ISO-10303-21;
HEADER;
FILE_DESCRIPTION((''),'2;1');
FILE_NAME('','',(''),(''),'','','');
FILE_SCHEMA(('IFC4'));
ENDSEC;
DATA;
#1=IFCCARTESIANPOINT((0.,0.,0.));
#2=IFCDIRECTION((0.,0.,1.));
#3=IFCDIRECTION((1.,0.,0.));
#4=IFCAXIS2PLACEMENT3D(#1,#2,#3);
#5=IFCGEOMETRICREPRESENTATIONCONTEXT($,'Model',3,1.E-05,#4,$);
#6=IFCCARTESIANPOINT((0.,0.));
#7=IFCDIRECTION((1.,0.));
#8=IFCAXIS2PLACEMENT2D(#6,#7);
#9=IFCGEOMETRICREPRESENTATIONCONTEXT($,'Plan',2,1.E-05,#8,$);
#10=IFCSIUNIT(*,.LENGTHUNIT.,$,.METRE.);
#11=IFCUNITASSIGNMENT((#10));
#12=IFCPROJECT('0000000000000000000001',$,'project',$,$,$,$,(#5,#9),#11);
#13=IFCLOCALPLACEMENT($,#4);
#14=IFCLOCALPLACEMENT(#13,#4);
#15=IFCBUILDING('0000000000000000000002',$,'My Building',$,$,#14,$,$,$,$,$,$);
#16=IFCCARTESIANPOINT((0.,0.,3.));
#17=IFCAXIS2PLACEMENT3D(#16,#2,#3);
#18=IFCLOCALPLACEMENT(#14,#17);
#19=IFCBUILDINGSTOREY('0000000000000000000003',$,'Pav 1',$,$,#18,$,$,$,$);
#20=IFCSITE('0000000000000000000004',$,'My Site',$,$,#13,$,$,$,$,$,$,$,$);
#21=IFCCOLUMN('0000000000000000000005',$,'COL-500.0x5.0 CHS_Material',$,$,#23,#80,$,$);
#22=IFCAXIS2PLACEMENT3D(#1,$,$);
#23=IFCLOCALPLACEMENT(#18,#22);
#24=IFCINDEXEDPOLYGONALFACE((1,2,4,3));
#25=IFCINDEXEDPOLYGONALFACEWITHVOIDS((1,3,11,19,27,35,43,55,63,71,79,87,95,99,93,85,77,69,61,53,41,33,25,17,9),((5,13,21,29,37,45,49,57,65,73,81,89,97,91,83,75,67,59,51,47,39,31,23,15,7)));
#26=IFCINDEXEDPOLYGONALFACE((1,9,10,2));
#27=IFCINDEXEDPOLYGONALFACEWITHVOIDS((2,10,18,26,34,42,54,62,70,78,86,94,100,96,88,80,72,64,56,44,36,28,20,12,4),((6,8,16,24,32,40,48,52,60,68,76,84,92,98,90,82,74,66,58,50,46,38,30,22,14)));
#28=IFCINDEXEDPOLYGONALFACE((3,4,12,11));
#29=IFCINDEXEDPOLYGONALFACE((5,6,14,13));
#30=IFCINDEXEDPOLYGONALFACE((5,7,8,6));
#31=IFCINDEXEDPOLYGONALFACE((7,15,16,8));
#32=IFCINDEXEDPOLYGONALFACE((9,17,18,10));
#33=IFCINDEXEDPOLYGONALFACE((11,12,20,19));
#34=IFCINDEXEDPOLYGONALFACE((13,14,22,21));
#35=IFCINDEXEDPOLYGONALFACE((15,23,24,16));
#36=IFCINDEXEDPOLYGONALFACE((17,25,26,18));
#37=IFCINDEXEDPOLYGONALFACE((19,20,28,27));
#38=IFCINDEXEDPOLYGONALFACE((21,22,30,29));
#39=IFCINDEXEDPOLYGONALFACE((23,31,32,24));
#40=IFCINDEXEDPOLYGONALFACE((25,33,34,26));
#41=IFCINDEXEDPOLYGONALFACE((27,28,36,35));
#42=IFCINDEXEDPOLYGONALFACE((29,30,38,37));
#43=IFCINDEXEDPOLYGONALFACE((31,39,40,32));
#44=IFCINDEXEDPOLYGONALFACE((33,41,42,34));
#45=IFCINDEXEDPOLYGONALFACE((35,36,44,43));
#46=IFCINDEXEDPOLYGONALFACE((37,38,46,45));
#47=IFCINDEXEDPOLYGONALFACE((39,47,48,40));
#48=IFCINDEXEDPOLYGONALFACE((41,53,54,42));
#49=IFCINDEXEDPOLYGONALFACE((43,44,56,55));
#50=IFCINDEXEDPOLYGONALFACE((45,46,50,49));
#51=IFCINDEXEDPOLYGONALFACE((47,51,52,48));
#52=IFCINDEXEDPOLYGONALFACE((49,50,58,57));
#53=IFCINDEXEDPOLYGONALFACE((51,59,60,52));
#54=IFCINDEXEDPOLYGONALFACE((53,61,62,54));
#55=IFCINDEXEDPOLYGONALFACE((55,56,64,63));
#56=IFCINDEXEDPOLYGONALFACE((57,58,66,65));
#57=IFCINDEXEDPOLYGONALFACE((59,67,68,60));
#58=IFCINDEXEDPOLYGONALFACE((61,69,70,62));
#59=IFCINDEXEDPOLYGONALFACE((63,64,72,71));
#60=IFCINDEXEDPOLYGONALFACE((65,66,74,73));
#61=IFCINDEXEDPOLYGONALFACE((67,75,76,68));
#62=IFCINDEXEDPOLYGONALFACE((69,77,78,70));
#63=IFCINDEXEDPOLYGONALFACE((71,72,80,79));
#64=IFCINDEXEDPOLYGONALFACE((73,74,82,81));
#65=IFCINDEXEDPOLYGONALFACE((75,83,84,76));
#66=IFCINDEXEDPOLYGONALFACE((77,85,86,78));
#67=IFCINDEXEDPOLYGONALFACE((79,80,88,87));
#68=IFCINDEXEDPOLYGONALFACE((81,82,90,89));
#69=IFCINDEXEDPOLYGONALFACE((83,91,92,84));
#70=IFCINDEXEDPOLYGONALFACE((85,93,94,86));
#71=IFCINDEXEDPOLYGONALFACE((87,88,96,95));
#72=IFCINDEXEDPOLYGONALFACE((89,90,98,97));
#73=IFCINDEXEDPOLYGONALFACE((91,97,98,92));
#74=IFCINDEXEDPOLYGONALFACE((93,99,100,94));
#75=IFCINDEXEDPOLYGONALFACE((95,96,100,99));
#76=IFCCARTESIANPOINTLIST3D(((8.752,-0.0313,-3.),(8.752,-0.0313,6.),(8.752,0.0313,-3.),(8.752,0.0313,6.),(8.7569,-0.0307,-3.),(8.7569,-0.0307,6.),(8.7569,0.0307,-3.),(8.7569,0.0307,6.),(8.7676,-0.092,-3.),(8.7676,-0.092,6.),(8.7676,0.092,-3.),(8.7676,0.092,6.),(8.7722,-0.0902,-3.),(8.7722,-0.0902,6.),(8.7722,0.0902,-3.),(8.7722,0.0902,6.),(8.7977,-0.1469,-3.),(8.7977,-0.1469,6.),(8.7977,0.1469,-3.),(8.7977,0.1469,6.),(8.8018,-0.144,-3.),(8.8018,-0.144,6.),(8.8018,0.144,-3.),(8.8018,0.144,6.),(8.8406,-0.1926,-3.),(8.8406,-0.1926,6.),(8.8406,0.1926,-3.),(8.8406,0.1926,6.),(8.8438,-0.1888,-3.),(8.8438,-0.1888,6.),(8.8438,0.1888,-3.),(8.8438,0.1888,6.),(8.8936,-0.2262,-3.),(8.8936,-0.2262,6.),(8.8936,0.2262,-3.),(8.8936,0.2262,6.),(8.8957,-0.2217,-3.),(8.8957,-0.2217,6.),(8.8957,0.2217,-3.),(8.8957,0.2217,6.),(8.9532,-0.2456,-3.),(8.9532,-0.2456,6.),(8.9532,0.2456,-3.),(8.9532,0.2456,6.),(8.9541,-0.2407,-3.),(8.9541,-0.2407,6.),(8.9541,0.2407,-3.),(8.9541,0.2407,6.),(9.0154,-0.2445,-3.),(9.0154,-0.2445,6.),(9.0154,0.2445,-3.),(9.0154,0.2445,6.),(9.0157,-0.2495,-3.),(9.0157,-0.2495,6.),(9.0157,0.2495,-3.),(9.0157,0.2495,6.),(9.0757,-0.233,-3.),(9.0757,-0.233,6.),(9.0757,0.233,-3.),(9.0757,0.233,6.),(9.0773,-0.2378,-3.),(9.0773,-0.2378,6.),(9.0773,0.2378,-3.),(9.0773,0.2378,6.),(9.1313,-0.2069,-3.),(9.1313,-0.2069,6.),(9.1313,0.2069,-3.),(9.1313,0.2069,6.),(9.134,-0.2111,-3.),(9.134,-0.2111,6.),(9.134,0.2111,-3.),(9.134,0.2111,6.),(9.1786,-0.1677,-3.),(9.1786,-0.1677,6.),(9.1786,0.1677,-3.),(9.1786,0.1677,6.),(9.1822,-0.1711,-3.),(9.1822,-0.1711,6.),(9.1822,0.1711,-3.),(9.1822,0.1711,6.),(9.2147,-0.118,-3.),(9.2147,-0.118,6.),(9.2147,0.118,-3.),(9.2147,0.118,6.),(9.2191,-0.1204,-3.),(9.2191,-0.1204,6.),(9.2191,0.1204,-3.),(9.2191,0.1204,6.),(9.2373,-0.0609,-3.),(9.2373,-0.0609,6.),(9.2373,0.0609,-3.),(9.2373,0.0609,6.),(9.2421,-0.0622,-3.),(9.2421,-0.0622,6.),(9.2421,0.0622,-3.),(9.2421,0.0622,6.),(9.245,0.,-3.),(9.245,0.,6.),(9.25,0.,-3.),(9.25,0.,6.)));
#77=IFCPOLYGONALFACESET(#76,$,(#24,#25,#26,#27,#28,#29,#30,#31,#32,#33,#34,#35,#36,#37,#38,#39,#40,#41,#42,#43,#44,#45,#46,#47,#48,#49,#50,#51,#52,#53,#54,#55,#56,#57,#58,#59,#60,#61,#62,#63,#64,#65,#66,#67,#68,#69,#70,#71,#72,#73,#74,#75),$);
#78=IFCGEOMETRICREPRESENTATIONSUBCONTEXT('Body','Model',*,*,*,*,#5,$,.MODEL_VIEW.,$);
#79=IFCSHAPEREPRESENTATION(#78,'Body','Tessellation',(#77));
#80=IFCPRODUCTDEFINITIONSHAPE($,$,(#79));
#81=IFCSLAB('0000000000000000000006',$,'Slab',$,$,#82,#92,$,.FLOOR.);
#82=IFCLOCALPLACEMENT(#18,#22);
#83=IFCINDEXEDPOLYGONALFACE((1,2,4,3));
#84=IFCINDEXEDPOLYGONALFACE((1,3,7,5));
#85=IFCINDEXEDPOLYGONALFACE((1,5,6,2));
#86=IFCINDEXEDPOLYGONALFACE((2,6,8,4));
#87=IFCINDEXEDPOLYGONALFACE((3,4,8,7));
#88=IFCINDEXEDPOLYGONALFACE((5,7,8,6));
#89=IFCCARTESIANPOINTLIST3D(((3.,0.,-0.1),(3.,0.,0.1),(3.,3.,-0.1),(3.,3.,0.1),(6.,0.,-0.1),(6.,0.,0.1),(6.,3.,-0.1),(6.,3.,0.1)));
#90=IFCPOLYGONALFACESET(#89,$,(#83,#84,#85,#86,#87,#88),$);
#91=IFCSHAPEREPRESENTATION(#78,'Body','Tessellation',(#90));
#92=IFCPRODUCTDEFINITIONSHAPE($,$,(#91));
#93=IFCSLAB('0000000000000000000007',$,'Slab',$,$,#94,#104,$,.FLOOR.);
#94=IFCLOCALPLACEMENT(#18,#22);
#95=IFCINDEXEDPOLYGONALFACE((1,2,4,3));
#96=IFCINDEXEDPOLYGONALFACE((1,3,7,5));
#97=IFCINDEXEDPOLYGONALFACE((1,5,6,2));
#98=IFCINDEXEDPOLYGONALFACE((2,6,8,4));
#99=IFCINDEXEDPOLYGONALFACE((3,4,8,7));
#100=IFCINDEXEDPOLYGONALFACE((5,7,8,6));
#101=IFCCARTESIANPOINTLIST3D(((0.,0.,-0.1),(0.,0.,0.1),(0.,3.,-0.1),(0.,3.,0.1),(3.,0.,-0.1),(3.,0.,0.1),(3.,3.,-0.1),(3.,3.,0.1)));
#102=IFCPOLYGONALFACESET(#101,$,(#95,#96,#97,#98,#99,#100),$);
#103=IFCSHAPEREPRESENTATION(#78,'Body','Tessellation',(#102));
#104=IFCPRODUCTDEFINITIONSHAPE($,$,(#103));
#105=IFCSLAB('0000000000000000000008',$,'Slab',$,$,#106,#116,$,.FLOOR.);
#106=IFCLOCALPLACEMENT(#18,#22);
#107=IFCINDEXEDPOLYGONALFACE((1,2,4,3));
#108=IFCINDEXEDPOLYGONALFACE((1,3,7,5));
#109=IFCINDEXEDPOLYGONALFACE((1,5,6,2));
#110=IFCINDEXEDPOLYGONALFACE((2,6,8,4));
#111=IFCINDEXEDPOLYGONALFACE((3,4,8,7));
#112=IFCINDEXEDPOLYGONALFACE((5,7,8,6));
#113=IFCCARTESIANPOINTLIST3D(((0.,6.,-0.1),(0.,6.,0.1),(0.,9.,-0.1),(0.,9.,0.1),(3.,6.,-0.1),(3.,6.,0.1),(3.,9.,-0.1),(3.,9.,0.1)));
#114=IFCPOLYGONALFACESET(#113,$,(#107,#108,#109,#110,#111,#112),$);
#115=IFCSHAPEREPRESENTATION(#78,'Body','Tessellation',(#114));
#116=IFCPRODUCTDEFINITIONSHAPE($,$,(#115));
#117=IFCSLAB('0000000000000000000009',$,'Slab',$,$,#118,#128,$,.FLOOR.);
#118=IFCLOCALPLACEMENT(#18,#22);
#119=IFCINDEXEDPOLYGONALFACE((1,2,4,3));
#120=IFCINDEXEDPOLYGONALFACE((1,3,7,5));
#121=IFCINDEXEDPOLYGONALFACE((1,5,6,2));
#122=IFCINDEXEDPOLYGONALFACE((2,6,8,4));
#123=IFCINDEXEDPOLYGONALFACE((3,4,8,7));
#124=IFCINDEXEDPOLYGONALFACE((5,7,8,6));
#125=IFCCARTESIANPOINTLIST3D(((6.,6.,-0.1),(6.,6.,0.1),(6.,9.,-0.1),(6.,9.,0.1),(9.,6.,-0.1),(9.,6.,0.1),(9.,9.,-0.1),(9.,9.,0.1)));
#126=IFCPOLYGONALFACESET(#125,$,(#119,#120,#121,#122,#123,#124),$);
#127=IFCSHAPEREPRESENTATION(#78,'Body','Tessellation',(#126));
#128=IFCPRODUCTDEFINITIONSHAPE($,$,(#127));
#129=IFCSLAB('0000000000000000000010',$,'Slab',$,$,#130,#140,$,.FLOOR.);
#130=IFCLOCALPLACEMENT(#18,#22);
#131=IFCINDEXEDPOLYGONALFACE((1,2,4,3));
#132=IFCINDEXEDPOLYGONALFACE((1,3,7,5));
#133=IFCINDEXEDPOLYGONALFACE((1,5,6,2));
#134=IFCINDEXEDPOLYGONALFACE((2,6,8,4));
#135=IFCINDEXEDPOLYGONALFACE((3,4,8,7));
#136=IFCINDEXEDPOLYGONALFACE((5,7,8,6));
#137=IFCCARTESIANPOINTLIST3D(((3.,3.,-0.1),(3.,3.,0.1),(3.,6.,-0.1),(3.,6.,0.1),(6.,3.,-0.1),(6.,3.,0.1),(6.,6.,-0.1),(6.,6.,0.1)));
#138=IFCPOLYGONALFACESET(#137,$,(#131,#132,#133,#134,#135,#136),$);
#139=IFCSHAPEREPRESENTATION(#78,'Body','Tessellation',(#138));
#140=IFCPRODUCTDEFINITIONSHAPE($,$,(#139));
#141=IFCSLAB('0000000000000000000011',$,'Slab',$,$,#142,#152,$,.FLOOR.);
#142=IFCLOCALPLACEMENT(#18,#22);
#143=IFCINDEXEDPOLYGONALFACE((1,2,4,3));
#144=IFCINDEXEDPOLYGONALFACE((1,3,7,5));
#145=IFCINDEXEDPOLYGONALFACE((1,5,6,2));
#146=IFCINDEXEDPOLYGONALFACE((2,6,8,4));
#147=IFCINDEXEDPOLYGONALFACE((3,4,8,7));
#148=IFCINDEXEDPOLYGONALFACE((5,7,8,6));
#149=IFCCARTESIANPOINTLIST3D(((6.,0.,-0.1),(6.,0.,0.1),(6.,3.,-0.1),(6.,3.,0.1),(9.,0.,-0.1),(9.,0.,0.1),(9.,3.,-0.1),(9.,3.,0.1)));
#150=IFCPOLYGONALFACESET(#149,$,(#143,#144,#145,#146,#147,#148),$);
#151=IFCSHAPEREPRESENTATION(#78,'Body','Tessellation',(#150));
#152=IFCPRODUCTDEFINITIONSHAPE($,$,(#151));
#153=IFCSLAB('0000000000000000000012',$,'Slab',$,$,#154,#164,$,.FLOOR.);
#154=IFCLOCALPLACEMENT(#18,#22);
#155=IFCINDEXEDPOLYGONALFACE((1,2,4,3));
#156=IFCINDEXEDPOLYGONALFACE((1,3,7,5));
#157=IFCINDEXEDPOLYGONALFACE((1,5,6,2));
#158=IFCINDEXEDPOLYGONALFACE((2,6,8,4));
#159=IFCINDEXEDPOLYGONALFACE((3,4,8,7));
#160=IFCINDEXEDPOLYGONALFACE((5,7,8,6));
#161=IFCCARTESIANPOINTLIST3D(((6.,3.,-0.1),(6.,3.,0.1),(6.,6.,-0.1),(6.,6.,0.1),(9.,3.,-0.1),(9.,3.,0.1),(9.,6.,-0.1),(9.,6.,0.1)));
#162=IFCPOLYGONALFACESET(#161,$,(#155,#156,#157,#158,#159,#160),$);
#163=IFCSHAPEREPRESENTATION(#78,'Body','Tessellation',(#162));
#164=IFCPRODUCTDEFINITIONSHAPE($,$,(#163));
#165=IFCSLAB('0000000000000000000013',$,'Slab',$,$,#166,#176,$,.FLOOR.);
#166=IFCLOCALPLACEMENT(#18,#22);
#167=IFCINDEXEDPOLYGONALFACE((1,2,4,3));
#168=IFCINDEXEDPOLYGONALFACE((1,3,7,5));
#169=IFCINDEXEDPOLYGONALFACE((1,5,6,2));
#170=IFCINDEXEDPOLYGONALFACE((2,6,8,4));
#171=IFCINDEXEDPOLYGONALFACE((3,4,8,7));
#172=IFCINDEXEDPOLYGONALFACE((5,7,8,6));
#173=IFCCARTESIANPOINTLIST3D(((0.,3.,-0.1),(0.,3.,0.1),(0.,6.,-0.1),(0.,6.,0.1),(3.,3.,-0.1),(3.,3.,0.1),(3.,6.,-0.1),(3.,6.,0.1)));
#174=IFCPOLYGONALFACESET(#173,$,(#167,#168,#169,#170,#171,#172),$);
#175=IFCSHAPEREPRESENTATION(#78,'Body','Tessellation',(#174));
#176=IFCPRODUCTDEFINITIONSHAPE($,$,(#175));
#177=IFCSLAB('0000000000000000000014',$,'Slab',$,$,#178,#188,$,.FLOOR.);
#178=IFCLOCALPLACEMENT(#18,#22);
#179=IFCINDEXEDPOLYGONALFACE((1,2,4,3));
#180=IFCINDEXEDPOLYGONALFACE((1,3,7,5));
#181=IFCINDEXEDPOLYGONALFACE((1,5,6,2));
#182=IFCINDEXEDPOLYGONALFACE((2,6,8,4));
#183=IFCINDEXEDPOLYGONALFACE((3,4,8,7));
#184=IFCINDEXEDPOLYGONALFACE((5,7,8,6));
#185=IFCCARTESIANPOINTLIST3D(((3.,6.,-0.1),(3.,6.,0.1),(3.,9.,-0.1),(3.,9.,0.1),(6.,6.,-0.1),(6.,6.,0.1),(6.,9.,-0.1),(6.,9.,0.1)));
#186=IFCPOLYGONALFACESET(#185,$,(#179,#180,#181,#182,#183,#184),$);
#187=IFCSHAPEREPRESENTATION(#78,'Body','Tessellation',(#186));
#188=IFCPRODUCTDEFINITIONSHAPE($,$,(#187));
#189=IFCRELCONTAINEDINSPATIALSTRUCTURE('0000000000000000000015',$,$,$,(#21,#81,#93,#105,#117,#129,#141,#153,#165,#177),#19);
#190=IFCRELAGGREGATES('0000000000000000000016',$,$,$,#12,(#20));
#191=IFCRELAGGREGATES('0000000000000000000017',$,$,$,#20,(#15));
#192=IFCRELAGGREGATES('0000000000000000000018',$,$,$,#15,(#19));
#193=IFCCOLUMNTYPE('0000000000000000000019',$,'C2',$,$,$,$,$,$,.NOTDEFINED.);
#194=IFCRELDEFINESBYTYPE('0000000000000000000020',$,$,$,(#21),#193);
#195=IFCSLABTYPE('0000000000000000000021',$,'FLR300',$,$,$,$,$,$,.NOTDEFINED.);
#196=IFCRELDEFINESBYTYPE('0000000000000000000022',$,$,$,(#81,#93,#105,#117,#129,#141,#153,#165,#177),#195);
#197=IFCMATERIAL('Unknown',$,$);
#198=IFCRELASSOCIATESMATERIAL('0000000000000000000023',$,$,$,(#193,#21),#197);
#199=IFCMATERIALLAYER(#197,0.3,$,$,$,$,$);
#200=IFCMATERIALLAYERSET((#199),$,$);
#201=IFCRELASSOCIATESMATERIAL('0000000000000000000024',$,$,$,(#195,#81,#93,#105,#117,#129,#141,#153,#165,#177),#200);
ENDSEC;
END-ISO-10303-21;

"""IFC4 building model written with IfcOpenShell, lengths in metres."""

from ifc_helpers import new_model, si_unit, frame, origin, origin_with_axes, origin_2d_with_axis, place, context, subcontext, project, spatial, polyline, hollow_circle, outline, extrude, material, layer, layer_set, layer_usage, material_profile, profile_set, profile_usage, type_object, element, save


model = new_model("IFC4")

# Units and contexts
model_context = context("Model", 3, precision=1e-05, world=origin_with_axes())
plan_context = context("Plan", 2, precision=1e-05, world=origin_2d_with_axis())
body_context = subcontext(model_context, "Body", "Model", "MODEL_VIEW")
ifc_project = project(units=[si_unit("LENGTHUNIT", "METRE")], contexts=[model_context, plan_context])

# Site, building, storey
site_placement = place(None, origin_with_axes())
site = spatial("IfcSite", under=ifc_project, at=site_placement, Name="My Site")
building_placement = place(site_placement, origin_with_axes())
building = spatial("IfcBuilding", under=site, at=building_placement, Name="My Building")
storey_placement = place(building_placement, frame((0.0, 0.0, 3.0), z_axis=(0.0, 0.0, 1.0), x_axis=(1.0, 0.0, 0.0)))
storey = spatial("IfcBuildingStorey", under=building, at=storey_placement, Name="Pav 1")

# Column
ifc_material = material(Name="Unknown")
ifc_material_profile = material_profile(ifc_material, hollow_circle(Radius=0.25, WallThickness=0.005))
ifc_profile_set = profile_set([ifc_material_profile])
column_type = type_object("IfcColumnType", Name="C2", PredefinedType="NOTDEFINED", material=ifc_profile_set)
ifc_profile_usage_1 = profile_usage(ifc_profile_set, cardinal=5)
column_1_placement = place(storey_placement, frame((9.0, 0.0, -3.0), z_axis=(0.0, 0.0, 1.0), x_axis=(1.0, 0.0, 0.0)))
element("IfcColumn", 1, at=column_1_placement, inside=storey, type_object=column_type, material=ifc_profile_usage_1, Name="COL-500.0x5.0 CHS_Material", context=body_context, shape_type="SweptSolid", body=[
    extrude(hollow_circle(Radius=0.25, WallThickness=0.005), origin(), (0.0, 0.0, 1.0), 9.0),
])

# Slabs
ifc_layer_1 = layer(ifc_material, 0.3)
ifc_layer_set_1 = layer_set([ifc_layer_1])
ifc_layer_usage_1 = layer_usage(ifc_layer_set_1, "AXIS3", "POSITIVE", 0.0)
slab_type = type_object("IfcSlabType", Name="FLR300", PredefinedType="NOTDEFINED", material=ifc_layer_set_1)
slab_1_placement = place(storey_placement, frame((4.5, 1.5, -0.1), z_axis=(0.0, 0.0, 1.0), x_axis=(1.0, 0.0, 0.0)))
element("IfcSlab", 2, at=slab_1_placement, inside=storey, type_object=slab_type, material=ifc_layer_usage_1, Name="Slab", PredefinedType="FLOOR", context=body_context, shape_type="SweptSolid", body=[
    extrude(outline(polyline([(1.5, 1.5), (-1.5, 1.5), (-1.5, -1.5), (1.5, -1.5), (1.5, 1.5)])), origin(), (0.0, 0.0, 1.0), 0.2),
])
ifc_layer_usage_2 = layer_usage(ifc_layer_set_1, "AXIS3", "POSITIVE", 0.0)
slab_2_placement = place(storey_placement, frame((1.5, 1.5, -0.1), z_axis=(0.0, 0.0, 1.0), x_axis=(1.0, 0.0, 0.0)))
element("IfcSlab", 3, at=slab_2_placement, inside=storey, type_object=slab_type, material=ifc_layer_usage_2, Name="Slab", PredefinedType="FLOOR", context=body_context, shape_type="SweptSolid", body=[
    extrude(outline(polyline([(1.5, 1.5), (-1.5, 1.5), (-1.5, -1.5), (1.5, -1.5), (1.5, 1.5)])), origin(), (0.0, 0.0, 1.0), 0.2),
])
ifc_layer_usage_3 = layer_usage(ifc_layer_set_1, "AXIS3", "POSITIVE", 0.0)
slab_3_placement = place(storey_placement, frame((1.5, 7.5, -0.1), z_axis=(0.0, 0.0, 1.0), x_axis=(1.0, 0.0, 0.0)))
element("IfcSlab", 4, at=slab_3_placement, inside=storey, type_object=slab_type, material=ifc_layer_usage_3, Name="Slab", PredefinedType="FLOOR", context=body_context, shape_type="SweptSolid", body=[
    extrude(outline(polyline([(1.5, 1.5), (-1.5, 1.5), (-1.5, -1.5), (1.5, -1.5), (1.5, 1.5)])), origin(), (0.0, 0.0, 1.0), 0.2),
])
ifc_layer_usage_4 = layer_usage(ifc_layer_set_1, "AXIS3", "POSITIVE", 0.0)
slab_4_placement = place(storey_placement, frame((7.5, 7.5, -0.1), z_axis=(0.0, 0.0, 1.0), x_axis=(1.0, 0.0, 0.0)))
element("IfcSlab", 5, at=slab_4_placement, inside=storey, type_object=slab_type, material=ifc_layer_usage_4, Name="Slab", PredefinedType="FLOOR", context=body_context, shape_type="SweptSolid", body=[
    extrude(outline(polyline([(1.5, 1.5), (-1.5, 1.5), (-1.5, -1.5), (1.5, -1.5), (1.5, 1.5)])), origin(), (0.0, 0.0, 1.0), 0.2),
])
ifc_layer_usage_5 = layer_usage(ifc_layer_set_1, "AXIS3", "POSITIVE", 0.0)
slab_5_placement = place(storey_placement, frame((4.5, 4.5, -0.1), z_axis=(0.0, 0.0, 1.0), x_axis=(1.0, 0.0, 0.0)))
element("IfcSlab", 6, at=slab_5_placement, inside=storey, type_object=slab_type, material=ifc_layer_usage_5, Name="Slab", PredefinedType="FLOOR", context=body_context, shape_type="SweptSolid", body=[
    extrude(outline(polyline([(1.5, 1.5), (-1.5, 1.5), (-1.5, -1.5), (1.5, -1.5), (1.5, 1.5)])), origin(), (0.0, 0.0, 1.0), 0.2),
])
ifc_layer_usage_6 = layer_usage(ifc_layer_set_1, "AXIS3", "POSITIVE", 0.0)
slab_6_placement = place(storey_placement, frame((7.5, 1.5, -0.1), z_axis=(0.0, 0.0, 1.0), x_axis=(1.0, 0.0, 0.0)))
element("IfcSlab", 7, at=slab_6_placement, inside=storey, type_object=slab_type, material=ifc_layer_usage_6, Name="Slab", PredefinedType="FLOOR", context=body_context, shape_type="SweptSolid", body=[
    extrude(outline(polyline([(1.5, 1.5), (-1.5, 1.5), (-1.5, -1.5), (1.5, -1.5), (1.5, 1.5)])), origin(), (0.0, 0.0, 1.0), 0.2),
])
ifc_layer_usage_7 = layer_usage(ifc_layer_set_1, "AXIS3", "POSITIVE", 0.0)
slab_7_placement = place(storey_placement, frame((7.5, 4.5, -0.1), z_axis=(0.0, 0.0, 1.0), x_axis=(1.0, 0.0, 0.0)))
element("IfcSlab", 8, at=slab_7_placement, inside=storey, type_object=slab_type, material=ifc_layer_usage_7, Name="Slab", PredefinedType="FLOOR", context=body_context, shape_type="SweptSolid", body=[
    extrude(outline(polyline([(1.5, 1.5), (-1.5, 1.5), (-1.5, -1.5), (1.5, -1.5), (1.5, 1.5)])), origin(), (0.0, 0.0, 1.0), 0.2),
])
ifc_layer_usage_8 = layer_usage(ifc_layer_set_1, "AXIS3", "POSITIVE", 0.0)
slab_8_placement = place(storey_placement, frame((1.5, 4.5, -0.1), z_axis=(0.0, 0.0, 1.0), x_axis=(1.0, 0.0, 0.0)))
element("IfcSlab", 9, at=slab_8_placement, inside=storey, type_object=slab_type, material=ifc_layer_usage_8, Name="Slab", PredefinedType="FLOOR", context=body_context, shape_type="SweptSolid", body=[
    extrude(outline(polyline([(1.5, 1.5), (-1.5, 1.5), (-1.5, -1.5), (1.5, -1.5), (1.5, 1.5)])), origin(), (0.0, 0.0, 1.0), 0.2),
])
ifc_layer_usage_9 = layer_usage(ifc_layer_set_1, "AXIS3", "POSITIVE", 0.0)
slab_9_placement = place(storey_placement, frame((4.5, 7.5, -0.1), z_axis=(0.0, 0.0, 1.0), x_axis=(1.0, 0.0, 0.0)))
element("IfcSlab", 10, at=slab_9_placement, inside=storey, type_object=slab_type, material=ifc_layer_usage_9, Name="Slab", PredefinedType="FLOOR", context=body_context, shape_type="SweptSolid", body=[
    extrude(outline(polyline([(1.5, 1.5), (-1.5, 1.5), (-1.5, -1.5), (1.5, -1.5), (1.5, 1.5)])), origin(), (0.0, 0.0, 1.0), 0.2),
])

save(model, "model.ifc")
